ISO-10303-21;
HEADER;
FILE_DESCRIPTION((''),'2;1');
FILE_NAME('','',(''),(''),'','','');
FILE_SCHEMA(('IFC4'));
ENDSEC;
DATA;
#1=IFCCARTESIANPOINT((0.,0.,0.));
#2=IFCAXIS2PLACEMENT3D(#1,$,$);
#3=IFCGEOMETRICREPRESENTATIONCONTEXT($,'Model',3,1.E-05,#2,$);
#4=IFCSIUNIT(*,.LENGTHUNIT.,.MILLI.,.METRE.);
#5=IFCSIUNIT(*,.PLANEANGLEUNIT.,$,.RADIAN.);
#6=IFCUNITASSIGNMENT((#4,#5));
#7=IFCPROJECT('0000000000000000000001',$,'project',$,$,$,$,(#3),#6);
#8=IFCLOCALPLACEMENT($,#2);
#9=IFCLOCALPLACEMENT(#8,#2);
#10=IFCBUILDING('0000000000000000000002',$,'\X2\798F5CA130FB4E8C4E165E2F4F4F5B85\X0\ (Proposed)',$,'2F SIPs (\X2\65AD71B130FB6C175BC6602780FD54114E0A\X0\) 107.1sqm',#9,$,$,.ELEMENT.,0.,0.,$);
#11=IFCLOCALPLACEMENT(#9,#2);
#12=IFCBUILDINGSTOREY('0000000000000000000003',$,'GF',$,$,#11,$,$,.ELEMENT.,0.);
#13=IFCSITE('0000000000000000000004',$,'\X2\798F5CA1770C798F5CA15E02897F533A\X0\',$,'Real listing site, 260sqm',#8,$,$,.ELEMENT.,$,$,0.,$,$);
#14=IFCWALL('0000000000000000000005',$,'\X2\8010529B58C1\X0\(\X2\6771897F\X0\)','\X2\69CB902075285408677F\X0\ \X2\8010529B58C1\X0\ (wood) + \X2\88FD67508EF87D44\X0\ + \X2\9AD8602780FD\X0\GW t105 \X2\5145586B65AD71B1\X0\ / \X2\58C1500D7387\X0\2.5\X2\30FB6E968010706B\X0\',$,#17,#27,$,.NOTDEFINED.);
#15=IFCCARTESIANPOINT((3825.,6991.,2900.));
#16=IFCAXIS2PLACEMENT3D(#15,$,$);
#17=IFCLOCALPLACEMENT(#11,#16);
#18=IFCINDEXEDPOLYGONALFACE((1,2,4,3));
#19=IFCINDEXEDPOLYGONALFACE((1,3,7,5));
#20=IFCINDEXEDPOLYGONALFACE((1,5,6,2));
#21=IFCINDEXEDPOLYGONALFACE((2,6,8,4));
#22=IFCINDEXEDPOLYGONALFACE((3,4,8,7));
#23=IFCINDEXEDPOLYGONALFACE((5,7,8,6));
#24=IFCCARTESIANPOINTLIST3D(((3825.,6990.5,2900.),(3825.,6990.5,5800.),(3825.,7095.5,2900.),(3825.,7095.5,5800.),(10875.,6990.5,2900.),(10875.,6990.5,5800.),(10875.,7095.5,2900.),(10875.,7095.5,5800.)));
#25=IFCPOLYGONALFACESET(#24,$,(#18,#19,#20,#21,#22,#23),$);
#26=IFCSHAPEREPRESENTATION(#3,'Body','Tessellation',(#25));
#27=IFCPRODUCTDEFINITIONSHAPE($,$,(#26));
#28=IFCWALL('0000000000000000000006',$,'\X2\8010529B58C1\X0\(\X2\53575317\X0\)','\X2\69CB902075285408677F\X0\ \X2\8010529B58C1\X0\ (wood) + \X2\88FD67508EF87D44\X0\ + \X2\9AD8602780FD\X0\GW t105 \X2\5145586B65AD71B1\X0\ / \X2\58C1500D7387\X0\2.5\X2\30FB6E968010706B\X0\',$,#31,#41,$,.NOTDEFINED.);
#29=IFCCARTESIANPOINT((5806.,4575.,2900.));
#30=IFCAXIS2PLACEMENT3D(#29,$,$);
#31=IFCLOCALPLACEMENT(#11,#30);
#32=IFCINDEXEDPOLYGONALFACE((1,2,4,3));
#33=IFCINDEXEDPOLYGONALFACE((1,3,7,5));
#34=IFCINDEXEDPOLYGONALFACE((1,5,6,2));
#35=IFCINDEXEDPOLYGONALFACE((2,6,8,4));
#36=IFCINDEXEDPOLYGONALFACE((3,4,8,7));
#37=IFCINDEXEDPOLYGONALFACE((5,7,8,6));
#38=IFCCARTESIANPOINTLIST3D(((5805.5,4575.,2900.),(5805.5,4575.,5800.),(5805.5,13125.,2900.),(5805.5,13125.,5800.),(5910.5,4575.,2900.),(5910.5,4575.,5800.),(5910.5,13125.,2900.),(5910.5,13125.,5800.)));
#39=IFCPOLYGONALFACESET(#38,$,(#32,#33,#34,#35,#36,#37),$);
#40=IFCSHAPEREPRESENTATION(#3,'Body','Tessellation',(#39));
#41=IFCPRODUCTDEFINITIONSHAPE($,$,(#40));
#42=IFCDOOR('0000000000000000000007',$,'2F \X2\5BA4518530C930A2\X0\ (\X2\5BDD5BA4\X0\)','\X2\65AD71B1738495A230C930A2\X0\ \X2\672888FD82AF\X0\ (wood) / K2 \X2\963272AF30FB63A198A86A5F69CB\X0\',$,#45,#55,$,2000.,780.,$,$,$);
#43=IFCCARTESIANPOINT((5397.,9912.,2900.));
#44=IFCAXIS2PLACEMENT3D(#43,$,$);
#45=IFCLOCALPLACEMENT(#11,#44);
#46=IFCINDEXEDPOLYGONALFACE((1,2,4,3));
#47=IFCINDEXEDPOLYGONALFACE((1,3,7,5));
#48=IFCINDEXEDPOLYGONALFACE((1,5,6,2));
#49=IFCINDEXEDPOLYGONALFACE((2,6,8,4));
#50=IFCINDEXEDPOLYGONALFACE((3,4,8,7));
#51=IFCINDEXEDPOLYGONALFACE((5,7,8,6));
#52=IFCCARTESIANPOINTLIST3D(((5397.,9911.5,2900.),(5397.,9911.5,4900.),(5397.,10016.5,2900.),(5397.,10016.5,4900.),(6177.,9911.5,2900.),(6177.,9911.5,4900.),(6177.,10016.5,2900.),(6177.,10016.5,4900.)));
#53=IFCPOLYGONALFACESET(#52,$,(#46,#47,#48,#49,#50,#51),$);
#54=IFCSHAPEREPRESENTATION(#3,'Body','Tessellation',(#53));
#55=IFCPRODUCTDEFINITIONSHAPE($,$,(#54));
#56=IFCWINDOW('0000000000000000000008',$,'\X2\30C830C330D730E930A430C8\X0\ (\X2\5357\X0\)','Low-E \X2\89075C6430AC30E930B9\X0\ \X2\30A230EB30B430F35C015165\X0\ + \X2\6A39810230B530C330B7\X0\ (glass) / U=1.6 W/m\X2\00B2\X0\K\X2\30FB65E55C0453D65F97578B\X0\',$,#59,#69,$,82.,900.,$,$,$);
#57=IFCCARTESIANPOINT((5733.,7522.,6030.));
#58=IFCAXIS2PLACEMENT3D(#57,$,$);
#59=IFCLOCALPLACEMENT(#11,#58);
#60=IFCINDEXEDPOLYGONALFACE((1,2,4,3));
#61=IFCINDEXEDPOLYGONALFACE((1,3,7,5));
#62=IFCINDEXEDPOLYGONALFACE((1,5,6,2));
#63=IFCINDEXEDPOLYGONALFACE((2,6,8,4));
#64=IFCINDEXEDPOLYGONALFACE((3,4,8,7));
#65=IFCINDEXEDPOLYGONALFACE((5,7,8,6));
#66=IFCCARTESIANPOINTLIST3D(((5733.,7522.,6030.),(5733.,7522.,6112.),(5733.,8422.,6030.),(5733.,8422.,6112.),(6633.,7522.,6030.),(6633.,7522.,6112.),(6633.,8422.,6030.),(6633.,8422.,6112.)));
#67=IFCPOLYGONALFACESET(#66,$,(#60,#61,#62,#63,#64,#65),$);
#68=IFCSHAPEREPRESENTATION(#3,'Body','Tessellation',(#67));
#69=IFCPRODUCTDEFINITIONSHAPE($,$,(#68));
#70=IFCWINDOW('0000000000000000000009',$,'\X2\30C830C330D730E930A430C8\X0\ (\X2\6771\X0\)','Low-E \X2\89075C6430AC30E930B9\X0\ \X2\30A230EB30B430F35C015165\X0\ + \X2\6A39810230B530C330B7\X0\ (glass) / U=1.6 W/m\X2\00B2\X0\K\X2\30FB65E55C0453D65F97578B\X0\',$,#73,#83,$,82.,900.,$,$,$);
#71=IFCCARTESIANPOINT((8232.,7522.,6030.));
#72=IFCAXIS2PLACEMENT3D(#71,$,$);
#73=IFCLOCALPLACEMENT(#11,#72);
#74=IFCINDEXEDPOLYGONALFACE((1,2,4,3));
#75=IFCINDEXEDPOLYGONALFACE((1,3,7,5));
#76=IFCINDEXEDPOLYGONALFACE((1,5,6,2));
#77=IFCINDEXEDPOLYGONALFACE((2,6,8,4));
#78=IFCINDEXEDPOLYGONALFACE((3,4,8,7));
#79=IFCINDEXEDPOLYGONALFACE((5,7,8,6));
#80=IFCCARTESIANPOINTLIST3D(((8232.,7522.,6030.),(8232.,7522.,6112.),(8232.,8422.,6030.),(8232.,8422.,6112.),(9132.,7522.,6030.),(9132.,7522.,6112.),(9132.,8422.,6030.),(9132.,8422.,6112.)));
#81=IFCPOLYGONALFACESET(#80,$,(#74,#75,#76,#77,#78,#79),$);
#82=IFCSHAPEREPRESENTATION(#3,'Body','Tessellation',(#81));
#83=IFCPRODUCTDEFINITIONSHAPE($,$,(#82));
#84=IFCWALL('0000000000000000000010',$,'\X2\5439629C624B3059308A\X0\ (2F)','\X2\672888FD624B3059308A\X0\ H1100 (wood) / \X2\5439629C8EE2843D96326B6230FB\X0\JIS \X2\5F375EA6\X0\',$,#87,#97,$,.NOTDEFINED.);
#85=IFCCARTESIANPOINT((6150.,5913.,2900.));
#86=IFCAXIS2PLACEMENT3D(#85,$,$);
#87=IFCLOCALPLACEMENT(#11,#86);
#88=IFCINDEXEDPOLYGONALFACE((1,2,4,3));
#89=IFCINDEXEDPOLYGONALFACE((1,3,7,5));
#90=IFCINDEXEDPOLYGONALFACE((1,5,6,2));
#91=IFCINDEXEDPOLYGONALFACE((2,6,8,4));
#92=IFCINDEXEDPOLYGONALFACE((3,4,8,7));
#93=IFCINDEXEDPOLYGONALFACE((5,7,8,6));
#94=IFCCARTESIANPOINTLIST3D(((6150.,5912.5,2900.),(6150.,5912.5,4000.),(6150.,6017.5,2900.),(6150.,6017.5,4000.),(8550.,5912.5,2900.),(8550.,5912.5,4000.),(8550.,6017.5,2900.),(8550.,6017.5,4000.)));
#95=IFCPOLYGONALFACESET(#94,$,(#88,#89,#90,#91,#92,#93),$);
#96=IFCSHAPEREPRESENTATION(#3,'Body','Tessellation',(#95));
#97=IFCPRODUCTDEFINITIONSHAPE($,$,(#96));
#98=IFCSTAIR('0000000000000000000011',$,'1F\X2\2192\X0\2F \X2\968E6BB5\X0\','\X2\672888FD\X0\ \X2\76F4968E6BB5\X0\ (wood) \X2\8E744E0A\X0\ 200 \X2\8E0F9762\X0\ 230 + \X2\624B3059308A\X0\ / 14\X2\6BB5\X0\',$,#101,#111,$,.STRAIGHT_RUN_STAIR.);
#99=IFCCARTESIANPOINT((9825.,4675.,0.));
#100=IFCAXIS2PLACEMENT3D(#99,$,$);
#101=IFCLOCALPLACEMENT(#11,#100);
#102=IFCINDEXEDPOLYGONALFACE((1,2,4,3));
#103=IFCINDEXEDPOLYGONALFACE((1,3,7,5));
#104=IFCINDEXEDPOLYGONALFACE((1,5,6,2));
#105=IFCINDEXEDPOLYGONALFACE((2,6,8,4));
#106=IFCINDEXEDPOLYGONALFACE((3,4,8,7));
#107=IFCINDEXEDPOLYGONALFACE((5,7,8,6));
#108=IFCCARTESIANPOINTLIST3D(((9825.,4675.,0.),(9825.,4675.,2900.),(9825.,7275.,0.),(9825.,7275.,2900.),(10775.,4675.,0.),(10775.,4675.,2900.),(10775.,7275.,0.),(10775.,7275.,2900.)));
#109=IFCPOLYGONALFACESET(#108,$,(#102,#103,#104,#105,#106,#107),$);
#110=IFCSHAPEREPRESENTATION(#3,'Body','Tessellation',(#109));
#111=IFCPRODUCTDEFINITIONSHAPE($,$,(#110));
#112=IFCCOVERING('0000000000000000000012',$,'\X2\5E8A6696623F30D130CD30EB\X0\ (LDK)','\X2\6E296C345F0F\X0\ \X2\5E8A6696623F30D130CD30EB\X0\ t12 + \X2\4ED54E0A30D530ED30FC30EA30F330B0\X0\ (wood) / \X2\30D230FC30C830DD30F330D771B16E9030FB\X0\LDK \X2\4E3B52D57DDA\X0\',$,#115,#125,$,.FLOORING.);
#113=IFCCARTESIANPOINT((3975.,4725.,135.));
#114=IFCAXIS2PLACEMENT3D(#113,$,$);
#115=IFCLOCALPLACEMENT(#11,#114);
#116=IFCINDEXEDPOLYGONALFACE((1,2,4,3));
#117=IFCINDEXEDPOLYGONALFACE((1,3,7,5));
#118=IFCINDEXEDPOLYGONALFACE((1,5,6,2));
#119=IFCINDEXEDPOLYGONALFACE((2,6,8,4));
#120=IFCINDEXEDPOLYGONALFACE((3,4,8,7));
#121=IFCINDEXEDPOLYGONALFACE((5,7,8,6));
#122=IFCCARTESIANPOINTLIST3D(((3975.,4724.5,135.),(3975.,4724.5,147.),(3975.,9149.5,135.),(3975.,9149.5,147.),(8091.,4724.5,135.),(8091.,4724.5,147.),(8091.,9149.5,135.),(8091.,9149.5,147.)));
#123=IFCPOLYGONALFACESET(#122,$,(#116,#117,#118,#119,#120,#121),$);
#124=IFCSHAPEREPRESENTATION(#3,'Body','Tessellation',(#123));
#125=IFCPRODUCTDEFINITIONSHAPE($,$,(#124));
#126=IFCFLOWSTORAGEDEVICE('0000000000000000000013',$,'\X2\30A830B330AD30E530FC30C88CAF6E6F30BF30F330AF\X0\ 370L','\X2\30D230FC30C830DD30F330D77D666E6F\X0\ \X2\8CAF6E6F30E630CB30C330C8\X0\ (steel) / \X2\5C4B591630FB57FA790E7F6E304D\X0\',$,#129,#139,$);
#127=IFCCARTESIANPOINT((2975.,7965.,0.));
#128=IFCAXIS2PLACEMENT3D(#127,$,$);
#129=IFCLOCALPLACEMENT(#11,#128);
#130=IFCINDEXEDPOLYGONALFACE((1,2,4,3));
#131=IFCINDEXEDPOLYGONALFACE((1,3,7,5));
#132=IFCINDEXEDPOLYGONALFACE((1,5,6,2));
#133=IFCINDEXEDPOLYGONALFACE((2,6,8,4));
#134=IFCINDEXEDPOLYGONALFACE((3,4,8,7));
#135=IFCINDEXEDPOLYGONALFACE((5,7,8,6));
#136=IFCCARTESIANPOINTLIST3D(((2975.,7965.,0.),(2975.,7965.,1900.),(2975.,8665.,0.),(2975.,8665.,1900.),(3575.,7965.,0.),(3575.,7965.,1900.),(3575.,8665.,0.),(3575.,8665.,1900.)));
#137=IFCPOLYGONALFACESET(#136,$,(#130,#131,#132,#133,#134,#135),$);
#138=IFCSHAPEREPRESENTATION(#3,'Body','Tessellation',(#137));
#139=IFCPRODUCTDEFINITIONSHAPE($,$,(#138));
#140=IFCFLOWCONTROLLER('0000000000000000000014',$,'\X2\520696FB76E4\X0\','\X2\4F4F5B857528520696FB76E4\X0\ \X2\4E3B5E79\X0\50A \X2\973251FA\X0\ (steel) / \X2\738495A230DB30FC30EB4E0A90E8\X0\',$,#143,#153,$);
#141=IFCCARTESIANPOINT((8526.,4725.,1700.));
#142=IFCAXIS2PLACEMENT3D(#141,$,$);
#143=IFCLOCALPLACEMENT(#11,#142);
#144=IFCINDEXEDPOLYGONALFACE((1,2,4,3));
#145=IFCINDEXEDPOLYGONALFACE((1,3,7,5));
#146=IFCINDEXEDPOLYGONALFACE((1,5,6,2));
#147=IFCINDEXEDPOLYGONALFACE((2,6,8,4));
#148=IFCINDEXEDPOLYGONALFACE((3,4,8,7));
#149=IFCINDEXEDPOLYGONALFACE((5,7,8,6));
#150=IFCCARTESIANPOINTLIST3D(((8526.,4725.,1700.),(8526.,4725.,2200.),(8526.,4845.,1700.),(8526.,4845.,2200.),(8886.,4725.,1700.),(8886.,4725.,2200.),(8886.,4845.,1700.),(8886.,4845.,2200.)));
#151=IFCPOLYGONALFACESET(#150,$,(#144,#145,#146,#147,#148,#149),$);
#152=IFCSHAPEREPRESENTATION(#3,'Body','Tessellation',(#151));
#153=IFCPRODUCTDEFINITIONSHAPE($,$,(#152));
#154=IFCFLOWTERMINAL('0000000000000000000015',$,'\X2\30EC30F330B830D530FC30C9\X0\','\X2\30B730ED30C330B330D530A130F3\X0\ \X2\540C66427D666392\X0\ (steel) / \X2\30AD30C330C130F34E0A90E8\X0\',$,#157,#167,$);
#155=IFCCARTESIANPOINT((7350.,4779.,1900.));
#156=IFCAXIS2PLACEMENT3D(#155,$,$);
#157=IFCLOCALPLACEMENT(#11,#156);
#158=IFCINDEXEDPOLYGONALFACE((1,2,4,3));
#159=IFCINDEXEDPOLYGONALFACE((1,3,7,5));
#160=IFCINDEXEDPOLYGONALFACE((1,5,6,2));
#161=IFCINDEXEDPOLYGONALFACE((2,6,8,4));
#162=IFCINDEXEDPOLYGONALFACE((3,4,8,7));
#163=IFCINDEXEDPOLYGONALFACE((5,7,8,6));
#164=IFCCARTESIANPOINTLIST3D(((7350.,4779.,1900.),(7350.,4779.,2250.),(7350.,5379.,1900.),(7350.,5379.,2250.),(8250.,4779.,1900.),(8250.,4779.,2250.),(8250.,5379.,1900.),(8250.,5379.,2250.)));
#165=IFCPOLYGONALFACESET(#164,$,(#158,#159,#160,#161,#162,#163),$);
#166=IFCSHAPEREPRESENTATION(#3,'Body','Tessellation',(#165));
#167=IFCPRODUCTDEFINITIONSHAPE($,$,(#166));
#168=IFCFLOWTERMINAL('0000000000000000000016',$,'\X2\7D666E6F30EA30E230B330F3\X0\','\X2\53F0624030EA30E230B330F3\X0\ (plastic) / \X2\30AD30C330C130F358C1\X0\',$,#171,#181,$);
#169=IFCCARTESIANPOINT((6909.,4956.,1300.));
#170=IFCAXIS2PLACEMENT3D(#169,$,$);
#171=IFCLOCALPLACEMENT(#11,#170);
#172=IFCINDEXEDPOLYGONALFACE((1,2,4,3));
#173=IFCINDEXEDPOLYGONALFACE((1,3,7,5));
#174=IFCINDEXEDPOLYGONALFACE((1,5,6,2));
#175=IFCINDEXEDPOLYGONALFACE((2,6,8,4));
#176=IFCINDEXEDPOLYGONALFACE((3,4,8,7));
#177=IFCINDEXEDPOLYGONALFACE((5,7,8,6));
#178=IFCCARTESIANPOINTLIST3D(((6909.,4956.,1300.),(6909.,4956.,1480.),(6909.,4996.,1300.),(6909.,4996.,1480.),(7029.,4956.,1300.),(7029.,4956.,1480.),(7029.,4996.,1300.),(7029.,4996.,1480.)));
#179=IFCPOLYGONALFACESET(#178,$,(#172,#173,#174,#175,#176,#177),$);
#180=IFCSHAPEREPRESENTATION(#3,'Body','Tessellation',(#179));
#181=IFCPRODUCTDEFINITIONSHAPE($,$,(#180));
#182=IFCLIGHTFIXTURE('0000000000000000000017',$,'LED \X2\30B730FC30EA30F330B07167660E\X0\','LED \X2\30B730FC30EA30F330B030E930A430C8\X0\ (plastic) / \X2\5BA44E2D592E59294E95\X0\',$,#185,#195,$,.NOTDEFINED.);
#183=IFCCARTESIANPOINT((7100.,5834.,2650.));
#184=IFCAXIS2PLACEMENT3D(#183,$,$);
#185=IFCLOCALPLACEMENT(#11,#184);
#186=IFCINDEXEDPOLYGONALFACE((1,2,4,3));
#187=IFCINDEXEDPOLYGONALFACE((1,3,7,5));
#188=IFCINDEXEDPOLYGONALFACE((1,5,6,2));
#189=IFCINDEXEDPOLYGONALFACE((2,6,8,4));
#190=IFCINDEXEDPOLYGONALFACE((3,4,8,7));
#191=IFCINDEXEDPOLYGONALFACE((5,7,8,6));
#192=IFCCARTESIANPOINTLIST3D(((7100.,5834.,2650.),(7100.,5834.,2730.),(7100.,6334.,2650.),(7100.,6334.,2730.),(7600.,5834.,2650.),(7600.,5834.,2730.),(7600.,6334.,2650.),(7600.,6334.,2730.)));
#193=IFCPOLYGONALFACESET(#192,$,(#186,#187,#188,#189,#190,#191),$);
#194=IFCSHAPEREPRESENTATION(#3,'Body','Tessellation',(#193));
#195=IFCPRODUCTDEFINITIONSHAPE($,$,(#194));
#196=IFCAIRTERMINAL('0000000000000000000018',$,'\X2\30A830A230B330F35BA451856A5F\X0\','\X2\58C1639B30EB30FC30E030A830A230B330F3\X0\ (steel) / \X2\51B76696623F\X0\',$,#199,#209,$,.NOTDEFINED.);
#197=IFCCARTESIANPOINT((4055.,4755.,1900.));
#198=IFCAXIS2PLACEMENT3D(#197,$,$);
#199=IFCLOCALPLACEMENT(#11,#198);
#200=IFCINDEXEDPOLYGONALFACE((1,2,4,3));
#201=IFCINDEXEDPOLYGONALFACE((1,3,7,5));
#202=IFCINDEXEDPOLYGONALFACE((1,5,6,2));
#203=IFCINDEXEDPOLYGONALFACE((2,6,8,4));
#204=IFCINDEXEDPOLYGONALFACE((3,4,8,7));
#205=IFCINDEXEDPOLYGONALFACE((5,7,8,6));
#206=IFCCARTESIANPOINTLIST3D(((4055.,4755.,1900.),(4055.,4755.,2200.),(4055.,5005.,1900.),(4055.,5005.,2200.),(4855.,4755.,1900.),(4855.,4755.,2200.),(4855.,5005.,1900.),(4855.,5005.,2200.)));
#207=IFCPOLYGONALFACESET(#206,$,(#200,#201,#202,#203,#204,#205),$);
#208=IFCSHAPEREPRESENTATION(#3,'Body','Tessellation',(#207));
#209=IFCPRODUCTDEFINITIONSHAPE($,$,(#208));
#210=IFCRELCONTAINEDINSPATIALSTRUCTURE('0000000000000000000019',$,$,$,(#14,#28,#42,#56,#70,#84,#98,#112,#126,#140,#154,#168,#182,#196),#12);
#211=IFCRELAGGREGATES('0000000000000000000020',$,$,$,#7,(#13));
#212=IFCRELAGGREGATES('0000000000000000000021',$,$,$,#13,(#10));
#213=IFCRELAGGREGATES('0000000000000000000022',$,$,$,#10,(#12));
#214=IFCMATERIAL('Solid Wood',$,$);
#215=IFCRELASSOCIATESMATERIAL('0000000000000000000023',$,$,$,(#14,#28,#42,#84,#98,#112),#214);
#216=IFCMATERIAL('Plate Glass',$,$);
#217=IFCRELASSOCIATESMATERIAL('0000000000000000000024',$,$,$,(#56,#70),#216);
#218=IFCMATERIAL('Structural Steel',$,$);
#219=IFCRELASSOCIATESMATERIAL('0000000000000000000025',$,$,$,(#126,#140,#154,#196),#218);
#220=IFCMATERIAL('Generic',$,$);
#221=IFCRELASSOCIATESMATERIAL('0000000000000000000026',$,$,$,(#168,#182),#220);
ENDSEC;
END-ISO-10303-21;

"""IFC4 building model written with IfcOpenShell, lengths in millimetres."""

from ifc_helpers import new_model, si_unit, frame, frame_2d, origin, place, context, project, spatial, rectangle, extrude, material, element, fill, save


model = new_model("IFC4")

# Units and contexts
model_context = context("Model", 3, precision=1e-05, world=origin())
ifc_project = project(units=[si_unit("LENGTHUNIT", "METRE", prefix="MILLI"), si_unit("PLANEANGLEUNIT", "RADIAN")], contexts=[model_context])

# Site, building, storey
site_placement = place(None, origin())
site = spatial("IfcSite", under=ifc_project, at=site_placement, Name="福岡県福岡市西区", ObjectType="Real listing site, 260sqm", CompositionType="ELEMENT", RefElevation=0.0)
building_placement = place(site_placement, origin())
building = spatial("IfcBuilding", under=site, at=building_placement, Name="福岡・二世帯住宅 (Proposed)", ObjectType="2F SIPs (断熱・気密性能向上) 107.1sqm", CompositionType="ELEMENT", ElevationOfRefHeight=0.0, ElevationOfTerrain=0.0)
storey_placement = place(building_placement, origin())
storey = spatial("IfcBuildingStorey", under=building, at=storey_placement, Name="GF", CompositionType="ELEMENT", Elevation=0.0)

# Shared definitions
ifc_material_1 = material(Name="Solid Wood")

# Wall
wall_1_placement = place(storey_placement, frame((3825.0, 6991.0, 2900.0)))
element("IfcWall", 1, at=wall_1_placement, inside=storey, material=ifc_material_1, Name="耐力壁(東西)", Description="構造用合板 耐力壁 (wood) + 製材軸組 + 高性能GW t105 充填断熱 / 壁倍率2.5・準耐火", PredefinedType="NOTDEFINED", context=model_context, shape_type="SweptSolid", body=[
    extrude(rectangle(XDim=7050.0, YDim=105.0, at=frame_2d((3525.0, 52.0))), frame((3825.0, 6991.0, 2900.0)), (0.0, 0.0, 1.0), 2900.0),
])

# Wall, opening, door
wall_2_placement = place(storey_placement, frame((5806.0, 4575.0, 2900.0)))
wall_2 = element("IfcWall", 2, at=wall_2_placement, inside=storey, material=ifc_material_1, Name="耐力壁(南北)", Description="構造用合板 耐力壁 (wood) + 製材軸組 + 高性能GW t105 充填断熱 / 壁倍率2.5・準耐火", PredefinedType="NOTDEFINED", context=model_context, shape_type="SweptSolid", body=[
    extrude(rectangle(XDim=105.0, YDim=8550.0, at=frame_2d((52.0, 4275.0))), frame((5806.0, 4575.0, 2900.0)), (0.0, 0.0, 1.0), 2900.0),
])
opening_placement = place(storey_placement, frame((5397.0, 9912.0, 2900.0)))
opening = element("IfcOpeningElement", 3, at=opening_placement, cuts=wall_2, PredefinedType="NOTDEFINED", context=model_context, shape_type="SweptSolid", body=[
    extrude(rectangle(XDim=780.0, YDim=105.0, at=frame_2d((390.0, 52.0))), frame((5397.0, 9912.0, 2900.0)), (0.0, 0.0, 1.0), 2000.0),
])
door_placement = place(storey_placement, frame((5397.0, 9912.0, 2900.0)))
door = element("IfcDoor", 4, at=door_placement, inside=storey, material=ifc_material_1, Name="2F 室内ドア (寝室)", Description="断熱玄関ドア 木製芯 (wood) / K2 防犯・採風機構", OverallHeight=2000.0, OverallWidth=780.0, context=model_context, shape_type="SweptSolid", body=[
    extrude(rectangle(XDim=780.0, YDim=105.0, at=frame_2d((390.0, 52.0))), frame((5397.0, 9912.0, 2900.0)), (0.0, 0.0, 1.0), 2000.0),
])
fill(opening, door)

# Windows
ifc_material_2 = material(Name="Plate Glass")
window_1_placement = place(storey_placement, frame((5733.0, 7522.0, 6030.0)))
element("IfcWindow", 5, at=window_1_placement, inside=storey, material=ifc_material_2, Name="トップライト (南)", Description="Low-E 複層ガラス アルゴン封入 + 樹脂サッシ (glass) / U=1.6 W/m²K・日射取得型", OverallHeight=82.0, OverallWidth=900.0, context=model_context, shape_type="SweptSolid", body=[
    extrude(rectangle(XDim=900.0, YDim=900.0, at=frame_2d((450.0, 450.0))), frame((5733.0, 7522.0, 6030.0)), (0.0, 0.0, 1.0), 82.0),
])
window_2_placement = place(storey_placement, frame((8232.0, 7522.0, 6030.0)))
element("IfcWindow", 6, at=window_2_placement, inside=storey, material=ifc_material_2, Name="トップライト (東)", Description="Low-E 複層ガラス アルゴン封入 + 樹脂サッシ (glass) / U=1.6 W/m²K・日射取得型", OverallHeight=82.0, OverallWidth=900.0, context=model_context, shape_type="SweptSolid", body=[
    extrude(rectangle(XDim=900.0, YDim=900.0, at=frame_2d((450.0, 450.0))), frame((8232.0, 7522.0, 6030.0)), (0.0, 0.0, 1.0), 82.0),
])

# Wall
wall_3_placement = place(storey_placement, frame((6150.0, 5913.0, 2900.0)))
element("IfcWall", 7, at=wall_3_placement, inside=storey, material=ifc_material_1, Name="吹抜手すり (2F)", Description="木製手すり H1100 (wood) / 吹抜転落防止・JIS 強度", PredefinedType="NOTDEFINED", context=model_context, shape_type="SweptSolid", body=[
    extrude(rectangle(XDim=2400.0, YDim=105.0, at=frame_2d((1200.0, 52.0))), frame((6150.0, 5913.0, 2900.0)), (0.0, 0.0, 1.0), 1100.0),
])

# Stair
stair_placement = place(storey_placement, frame((9825.0, 4675.0, 0.0)))
element("IfcStair", 8, at=stair_placement, inside=storey, material=ifc_material_1, Name="1F→2F 階段", Description="木製 直階段 (wood) 蹴上 200 踏面 230 + 手すり / 14段", PredefinedType="STRAIGHT_RUN_STAIR", context=model_context, shape_type="SweptSolid", body=[
    extrude(rectangle(XDim=950.0, YDim=2600.0, at=frame_2d((475.0, 1300.0))), frame((9825.0, 4675.0, 0.0)), (0.0, 0.0, 1.0), 2900.0),
])

# Covering
covering_placement = place(storey_placement, frame((3975.0, 4725.0, 135.0)))
element("IfcCovering", 9, at=covering_placement, inside=storey, material=ifc_material_1, Name="床暖房パネル (LDK)", Description="温水式 床暖房パネル t12 + 仕上フローリング (wood) / ヒートポンプ熱源・LDK 主動線", PredefinedType="FLOORING", context=model_context, shape_type="SweptSolid", body=[
    extrude(rectangle(XDim=4116.0, YDim=4425.0, at=frame_2d((2058.0, 2212.0))), frame((3975.0, 4725.0, 135.0)), (0.0, 0.0, 1.0), 12.0),
])

# Flow storage device
ifc_material_3 = material(Name="Structural Steel")
flow_storage_device_placement = place(storey_placement, frame((2975.0, 7965.0, 0.0)))
element("IfcFlowStorageDevice", 10, at=flow_storage_device_placement, inside=storey, material=ifc_material_3, Name="エコキュート貯湯タンク 370L", Description="ヒートポンプ給湯 貯湯ユニット (steel) / 屋外・基礎置き", context=model_context, shape_type="SweptSolid", body=[
    extrude(rectangle(XDim=600.0, YDim=700.0, at=frame_2d((300.0, 350.0))), frame((2975.0, 7965.0, 0.0)), (0.0, 0.0, 1.0), 1900.0),
])

# Flow controller
flow_controller_placement = place(storey_placement, frame((8526.0, 4725.0, 1700.0)))
element("IfcFlowController", 11, at=flow_controller_placement, inside=storey, material=ifc_material_3, Name="分電盤", Description="住宅用分電盤 主幹50A 露出 (steel) / 玄関ホール上部", context=model_context, shape_type="SweptSolid", body=[
    extrude(rectangle(XDim=360.0, YDim=120.0, at=frame_2d((180.0, 60.0))), frame((8526.0, 4725.0, 1700.0)), (0.0, 0.0, 1.0), 500.0),
])

# Flow terminals
flow_terminal_1_placement = place(storey_placement, frame((7350.0, 4779.0, 1900.0)))
element("IfcFlowTerminal", 12, at=flow_terminal_1_placement, inside=storey, material=ifc_material_3, Name="レンジフード", Description="シロッコファン 同時給排 (steel) / キッチン上部", context=model_context, shape_type="SweptSolid", body=[
    extrude(rectangle(XDim=900.0, YDim=600.0, at=frame_2d((450.0, 300.0))), frame((7350.0, 4779.0, 1900.0)), (0.0, 0.0, 1.0), 350.0),
])
ifc_material_4 = material(Name="Generic")
flow_terminal_2_placement = place(storey_placement, frame((6909.0, 4956.0, 1300.0)))
element("IfcFlowTerminal", 13, at=flow_terminal_2_placement, inside=storey, material=ifc_material_4, Name="給湯リモコン", Description="台所リモコン (plastic) / キッチン壁", context=model_context, shape_type="SweptSolid", body=[
    extrude(rectangle(XDim=120.0, YDim=40.0, at=frame_2d((60.0, 20.0))), frame((6909.0, 4956.0, 1300.0)), (0.0, 0.0, 1.0), 180.0),
])

# Light fixture
light_fixture_1_placement = place(storey_placement, frame((7100.0, 5834.0, 2650.0)))
element("IfcLightFixture", 14, at=light_fixture_1_placement, inside=storey, material=ifc_material_4, Name="LED シーリング照明", Description="LED シーリングライト (plastic) / 室中央天井", PredefinedType="NOTDEFINED", context=model_context, shape_type="SweptSolid", body=[
    extrude(rectangle(XDim=500.0, YDim=500.0, at=frame_2d((250.0, 250.0))), frame((7100.0, 5834.0, 2650.0)), (0.0, 0.0, 1.0), 80.0),
])

# Air terminal
air_terminal_1_placement = place(storey_placement, frame((4055.0, 4755.0, 1900.0)))
element("IfcAirTerminal", 15, at=air_terminal_1_placement, inside=storey, material=ifc_material_3, Name="エアコン室内機", Description="壁掛ルームエアコン (steel) / 冷暖房", PredefinedType="NOTDEFINED", context=model_context, shape_type="SweptSolid", body=[
    extrude(rectangle(XDim=800.0, YDim=250.0, at=frame_2d((400.0, 125.0))), frame((4055.0, 4755.0, 1900.0)), (0.0, 0.0, 1.0), 300.0),
])

save(model, "model.ifc")
